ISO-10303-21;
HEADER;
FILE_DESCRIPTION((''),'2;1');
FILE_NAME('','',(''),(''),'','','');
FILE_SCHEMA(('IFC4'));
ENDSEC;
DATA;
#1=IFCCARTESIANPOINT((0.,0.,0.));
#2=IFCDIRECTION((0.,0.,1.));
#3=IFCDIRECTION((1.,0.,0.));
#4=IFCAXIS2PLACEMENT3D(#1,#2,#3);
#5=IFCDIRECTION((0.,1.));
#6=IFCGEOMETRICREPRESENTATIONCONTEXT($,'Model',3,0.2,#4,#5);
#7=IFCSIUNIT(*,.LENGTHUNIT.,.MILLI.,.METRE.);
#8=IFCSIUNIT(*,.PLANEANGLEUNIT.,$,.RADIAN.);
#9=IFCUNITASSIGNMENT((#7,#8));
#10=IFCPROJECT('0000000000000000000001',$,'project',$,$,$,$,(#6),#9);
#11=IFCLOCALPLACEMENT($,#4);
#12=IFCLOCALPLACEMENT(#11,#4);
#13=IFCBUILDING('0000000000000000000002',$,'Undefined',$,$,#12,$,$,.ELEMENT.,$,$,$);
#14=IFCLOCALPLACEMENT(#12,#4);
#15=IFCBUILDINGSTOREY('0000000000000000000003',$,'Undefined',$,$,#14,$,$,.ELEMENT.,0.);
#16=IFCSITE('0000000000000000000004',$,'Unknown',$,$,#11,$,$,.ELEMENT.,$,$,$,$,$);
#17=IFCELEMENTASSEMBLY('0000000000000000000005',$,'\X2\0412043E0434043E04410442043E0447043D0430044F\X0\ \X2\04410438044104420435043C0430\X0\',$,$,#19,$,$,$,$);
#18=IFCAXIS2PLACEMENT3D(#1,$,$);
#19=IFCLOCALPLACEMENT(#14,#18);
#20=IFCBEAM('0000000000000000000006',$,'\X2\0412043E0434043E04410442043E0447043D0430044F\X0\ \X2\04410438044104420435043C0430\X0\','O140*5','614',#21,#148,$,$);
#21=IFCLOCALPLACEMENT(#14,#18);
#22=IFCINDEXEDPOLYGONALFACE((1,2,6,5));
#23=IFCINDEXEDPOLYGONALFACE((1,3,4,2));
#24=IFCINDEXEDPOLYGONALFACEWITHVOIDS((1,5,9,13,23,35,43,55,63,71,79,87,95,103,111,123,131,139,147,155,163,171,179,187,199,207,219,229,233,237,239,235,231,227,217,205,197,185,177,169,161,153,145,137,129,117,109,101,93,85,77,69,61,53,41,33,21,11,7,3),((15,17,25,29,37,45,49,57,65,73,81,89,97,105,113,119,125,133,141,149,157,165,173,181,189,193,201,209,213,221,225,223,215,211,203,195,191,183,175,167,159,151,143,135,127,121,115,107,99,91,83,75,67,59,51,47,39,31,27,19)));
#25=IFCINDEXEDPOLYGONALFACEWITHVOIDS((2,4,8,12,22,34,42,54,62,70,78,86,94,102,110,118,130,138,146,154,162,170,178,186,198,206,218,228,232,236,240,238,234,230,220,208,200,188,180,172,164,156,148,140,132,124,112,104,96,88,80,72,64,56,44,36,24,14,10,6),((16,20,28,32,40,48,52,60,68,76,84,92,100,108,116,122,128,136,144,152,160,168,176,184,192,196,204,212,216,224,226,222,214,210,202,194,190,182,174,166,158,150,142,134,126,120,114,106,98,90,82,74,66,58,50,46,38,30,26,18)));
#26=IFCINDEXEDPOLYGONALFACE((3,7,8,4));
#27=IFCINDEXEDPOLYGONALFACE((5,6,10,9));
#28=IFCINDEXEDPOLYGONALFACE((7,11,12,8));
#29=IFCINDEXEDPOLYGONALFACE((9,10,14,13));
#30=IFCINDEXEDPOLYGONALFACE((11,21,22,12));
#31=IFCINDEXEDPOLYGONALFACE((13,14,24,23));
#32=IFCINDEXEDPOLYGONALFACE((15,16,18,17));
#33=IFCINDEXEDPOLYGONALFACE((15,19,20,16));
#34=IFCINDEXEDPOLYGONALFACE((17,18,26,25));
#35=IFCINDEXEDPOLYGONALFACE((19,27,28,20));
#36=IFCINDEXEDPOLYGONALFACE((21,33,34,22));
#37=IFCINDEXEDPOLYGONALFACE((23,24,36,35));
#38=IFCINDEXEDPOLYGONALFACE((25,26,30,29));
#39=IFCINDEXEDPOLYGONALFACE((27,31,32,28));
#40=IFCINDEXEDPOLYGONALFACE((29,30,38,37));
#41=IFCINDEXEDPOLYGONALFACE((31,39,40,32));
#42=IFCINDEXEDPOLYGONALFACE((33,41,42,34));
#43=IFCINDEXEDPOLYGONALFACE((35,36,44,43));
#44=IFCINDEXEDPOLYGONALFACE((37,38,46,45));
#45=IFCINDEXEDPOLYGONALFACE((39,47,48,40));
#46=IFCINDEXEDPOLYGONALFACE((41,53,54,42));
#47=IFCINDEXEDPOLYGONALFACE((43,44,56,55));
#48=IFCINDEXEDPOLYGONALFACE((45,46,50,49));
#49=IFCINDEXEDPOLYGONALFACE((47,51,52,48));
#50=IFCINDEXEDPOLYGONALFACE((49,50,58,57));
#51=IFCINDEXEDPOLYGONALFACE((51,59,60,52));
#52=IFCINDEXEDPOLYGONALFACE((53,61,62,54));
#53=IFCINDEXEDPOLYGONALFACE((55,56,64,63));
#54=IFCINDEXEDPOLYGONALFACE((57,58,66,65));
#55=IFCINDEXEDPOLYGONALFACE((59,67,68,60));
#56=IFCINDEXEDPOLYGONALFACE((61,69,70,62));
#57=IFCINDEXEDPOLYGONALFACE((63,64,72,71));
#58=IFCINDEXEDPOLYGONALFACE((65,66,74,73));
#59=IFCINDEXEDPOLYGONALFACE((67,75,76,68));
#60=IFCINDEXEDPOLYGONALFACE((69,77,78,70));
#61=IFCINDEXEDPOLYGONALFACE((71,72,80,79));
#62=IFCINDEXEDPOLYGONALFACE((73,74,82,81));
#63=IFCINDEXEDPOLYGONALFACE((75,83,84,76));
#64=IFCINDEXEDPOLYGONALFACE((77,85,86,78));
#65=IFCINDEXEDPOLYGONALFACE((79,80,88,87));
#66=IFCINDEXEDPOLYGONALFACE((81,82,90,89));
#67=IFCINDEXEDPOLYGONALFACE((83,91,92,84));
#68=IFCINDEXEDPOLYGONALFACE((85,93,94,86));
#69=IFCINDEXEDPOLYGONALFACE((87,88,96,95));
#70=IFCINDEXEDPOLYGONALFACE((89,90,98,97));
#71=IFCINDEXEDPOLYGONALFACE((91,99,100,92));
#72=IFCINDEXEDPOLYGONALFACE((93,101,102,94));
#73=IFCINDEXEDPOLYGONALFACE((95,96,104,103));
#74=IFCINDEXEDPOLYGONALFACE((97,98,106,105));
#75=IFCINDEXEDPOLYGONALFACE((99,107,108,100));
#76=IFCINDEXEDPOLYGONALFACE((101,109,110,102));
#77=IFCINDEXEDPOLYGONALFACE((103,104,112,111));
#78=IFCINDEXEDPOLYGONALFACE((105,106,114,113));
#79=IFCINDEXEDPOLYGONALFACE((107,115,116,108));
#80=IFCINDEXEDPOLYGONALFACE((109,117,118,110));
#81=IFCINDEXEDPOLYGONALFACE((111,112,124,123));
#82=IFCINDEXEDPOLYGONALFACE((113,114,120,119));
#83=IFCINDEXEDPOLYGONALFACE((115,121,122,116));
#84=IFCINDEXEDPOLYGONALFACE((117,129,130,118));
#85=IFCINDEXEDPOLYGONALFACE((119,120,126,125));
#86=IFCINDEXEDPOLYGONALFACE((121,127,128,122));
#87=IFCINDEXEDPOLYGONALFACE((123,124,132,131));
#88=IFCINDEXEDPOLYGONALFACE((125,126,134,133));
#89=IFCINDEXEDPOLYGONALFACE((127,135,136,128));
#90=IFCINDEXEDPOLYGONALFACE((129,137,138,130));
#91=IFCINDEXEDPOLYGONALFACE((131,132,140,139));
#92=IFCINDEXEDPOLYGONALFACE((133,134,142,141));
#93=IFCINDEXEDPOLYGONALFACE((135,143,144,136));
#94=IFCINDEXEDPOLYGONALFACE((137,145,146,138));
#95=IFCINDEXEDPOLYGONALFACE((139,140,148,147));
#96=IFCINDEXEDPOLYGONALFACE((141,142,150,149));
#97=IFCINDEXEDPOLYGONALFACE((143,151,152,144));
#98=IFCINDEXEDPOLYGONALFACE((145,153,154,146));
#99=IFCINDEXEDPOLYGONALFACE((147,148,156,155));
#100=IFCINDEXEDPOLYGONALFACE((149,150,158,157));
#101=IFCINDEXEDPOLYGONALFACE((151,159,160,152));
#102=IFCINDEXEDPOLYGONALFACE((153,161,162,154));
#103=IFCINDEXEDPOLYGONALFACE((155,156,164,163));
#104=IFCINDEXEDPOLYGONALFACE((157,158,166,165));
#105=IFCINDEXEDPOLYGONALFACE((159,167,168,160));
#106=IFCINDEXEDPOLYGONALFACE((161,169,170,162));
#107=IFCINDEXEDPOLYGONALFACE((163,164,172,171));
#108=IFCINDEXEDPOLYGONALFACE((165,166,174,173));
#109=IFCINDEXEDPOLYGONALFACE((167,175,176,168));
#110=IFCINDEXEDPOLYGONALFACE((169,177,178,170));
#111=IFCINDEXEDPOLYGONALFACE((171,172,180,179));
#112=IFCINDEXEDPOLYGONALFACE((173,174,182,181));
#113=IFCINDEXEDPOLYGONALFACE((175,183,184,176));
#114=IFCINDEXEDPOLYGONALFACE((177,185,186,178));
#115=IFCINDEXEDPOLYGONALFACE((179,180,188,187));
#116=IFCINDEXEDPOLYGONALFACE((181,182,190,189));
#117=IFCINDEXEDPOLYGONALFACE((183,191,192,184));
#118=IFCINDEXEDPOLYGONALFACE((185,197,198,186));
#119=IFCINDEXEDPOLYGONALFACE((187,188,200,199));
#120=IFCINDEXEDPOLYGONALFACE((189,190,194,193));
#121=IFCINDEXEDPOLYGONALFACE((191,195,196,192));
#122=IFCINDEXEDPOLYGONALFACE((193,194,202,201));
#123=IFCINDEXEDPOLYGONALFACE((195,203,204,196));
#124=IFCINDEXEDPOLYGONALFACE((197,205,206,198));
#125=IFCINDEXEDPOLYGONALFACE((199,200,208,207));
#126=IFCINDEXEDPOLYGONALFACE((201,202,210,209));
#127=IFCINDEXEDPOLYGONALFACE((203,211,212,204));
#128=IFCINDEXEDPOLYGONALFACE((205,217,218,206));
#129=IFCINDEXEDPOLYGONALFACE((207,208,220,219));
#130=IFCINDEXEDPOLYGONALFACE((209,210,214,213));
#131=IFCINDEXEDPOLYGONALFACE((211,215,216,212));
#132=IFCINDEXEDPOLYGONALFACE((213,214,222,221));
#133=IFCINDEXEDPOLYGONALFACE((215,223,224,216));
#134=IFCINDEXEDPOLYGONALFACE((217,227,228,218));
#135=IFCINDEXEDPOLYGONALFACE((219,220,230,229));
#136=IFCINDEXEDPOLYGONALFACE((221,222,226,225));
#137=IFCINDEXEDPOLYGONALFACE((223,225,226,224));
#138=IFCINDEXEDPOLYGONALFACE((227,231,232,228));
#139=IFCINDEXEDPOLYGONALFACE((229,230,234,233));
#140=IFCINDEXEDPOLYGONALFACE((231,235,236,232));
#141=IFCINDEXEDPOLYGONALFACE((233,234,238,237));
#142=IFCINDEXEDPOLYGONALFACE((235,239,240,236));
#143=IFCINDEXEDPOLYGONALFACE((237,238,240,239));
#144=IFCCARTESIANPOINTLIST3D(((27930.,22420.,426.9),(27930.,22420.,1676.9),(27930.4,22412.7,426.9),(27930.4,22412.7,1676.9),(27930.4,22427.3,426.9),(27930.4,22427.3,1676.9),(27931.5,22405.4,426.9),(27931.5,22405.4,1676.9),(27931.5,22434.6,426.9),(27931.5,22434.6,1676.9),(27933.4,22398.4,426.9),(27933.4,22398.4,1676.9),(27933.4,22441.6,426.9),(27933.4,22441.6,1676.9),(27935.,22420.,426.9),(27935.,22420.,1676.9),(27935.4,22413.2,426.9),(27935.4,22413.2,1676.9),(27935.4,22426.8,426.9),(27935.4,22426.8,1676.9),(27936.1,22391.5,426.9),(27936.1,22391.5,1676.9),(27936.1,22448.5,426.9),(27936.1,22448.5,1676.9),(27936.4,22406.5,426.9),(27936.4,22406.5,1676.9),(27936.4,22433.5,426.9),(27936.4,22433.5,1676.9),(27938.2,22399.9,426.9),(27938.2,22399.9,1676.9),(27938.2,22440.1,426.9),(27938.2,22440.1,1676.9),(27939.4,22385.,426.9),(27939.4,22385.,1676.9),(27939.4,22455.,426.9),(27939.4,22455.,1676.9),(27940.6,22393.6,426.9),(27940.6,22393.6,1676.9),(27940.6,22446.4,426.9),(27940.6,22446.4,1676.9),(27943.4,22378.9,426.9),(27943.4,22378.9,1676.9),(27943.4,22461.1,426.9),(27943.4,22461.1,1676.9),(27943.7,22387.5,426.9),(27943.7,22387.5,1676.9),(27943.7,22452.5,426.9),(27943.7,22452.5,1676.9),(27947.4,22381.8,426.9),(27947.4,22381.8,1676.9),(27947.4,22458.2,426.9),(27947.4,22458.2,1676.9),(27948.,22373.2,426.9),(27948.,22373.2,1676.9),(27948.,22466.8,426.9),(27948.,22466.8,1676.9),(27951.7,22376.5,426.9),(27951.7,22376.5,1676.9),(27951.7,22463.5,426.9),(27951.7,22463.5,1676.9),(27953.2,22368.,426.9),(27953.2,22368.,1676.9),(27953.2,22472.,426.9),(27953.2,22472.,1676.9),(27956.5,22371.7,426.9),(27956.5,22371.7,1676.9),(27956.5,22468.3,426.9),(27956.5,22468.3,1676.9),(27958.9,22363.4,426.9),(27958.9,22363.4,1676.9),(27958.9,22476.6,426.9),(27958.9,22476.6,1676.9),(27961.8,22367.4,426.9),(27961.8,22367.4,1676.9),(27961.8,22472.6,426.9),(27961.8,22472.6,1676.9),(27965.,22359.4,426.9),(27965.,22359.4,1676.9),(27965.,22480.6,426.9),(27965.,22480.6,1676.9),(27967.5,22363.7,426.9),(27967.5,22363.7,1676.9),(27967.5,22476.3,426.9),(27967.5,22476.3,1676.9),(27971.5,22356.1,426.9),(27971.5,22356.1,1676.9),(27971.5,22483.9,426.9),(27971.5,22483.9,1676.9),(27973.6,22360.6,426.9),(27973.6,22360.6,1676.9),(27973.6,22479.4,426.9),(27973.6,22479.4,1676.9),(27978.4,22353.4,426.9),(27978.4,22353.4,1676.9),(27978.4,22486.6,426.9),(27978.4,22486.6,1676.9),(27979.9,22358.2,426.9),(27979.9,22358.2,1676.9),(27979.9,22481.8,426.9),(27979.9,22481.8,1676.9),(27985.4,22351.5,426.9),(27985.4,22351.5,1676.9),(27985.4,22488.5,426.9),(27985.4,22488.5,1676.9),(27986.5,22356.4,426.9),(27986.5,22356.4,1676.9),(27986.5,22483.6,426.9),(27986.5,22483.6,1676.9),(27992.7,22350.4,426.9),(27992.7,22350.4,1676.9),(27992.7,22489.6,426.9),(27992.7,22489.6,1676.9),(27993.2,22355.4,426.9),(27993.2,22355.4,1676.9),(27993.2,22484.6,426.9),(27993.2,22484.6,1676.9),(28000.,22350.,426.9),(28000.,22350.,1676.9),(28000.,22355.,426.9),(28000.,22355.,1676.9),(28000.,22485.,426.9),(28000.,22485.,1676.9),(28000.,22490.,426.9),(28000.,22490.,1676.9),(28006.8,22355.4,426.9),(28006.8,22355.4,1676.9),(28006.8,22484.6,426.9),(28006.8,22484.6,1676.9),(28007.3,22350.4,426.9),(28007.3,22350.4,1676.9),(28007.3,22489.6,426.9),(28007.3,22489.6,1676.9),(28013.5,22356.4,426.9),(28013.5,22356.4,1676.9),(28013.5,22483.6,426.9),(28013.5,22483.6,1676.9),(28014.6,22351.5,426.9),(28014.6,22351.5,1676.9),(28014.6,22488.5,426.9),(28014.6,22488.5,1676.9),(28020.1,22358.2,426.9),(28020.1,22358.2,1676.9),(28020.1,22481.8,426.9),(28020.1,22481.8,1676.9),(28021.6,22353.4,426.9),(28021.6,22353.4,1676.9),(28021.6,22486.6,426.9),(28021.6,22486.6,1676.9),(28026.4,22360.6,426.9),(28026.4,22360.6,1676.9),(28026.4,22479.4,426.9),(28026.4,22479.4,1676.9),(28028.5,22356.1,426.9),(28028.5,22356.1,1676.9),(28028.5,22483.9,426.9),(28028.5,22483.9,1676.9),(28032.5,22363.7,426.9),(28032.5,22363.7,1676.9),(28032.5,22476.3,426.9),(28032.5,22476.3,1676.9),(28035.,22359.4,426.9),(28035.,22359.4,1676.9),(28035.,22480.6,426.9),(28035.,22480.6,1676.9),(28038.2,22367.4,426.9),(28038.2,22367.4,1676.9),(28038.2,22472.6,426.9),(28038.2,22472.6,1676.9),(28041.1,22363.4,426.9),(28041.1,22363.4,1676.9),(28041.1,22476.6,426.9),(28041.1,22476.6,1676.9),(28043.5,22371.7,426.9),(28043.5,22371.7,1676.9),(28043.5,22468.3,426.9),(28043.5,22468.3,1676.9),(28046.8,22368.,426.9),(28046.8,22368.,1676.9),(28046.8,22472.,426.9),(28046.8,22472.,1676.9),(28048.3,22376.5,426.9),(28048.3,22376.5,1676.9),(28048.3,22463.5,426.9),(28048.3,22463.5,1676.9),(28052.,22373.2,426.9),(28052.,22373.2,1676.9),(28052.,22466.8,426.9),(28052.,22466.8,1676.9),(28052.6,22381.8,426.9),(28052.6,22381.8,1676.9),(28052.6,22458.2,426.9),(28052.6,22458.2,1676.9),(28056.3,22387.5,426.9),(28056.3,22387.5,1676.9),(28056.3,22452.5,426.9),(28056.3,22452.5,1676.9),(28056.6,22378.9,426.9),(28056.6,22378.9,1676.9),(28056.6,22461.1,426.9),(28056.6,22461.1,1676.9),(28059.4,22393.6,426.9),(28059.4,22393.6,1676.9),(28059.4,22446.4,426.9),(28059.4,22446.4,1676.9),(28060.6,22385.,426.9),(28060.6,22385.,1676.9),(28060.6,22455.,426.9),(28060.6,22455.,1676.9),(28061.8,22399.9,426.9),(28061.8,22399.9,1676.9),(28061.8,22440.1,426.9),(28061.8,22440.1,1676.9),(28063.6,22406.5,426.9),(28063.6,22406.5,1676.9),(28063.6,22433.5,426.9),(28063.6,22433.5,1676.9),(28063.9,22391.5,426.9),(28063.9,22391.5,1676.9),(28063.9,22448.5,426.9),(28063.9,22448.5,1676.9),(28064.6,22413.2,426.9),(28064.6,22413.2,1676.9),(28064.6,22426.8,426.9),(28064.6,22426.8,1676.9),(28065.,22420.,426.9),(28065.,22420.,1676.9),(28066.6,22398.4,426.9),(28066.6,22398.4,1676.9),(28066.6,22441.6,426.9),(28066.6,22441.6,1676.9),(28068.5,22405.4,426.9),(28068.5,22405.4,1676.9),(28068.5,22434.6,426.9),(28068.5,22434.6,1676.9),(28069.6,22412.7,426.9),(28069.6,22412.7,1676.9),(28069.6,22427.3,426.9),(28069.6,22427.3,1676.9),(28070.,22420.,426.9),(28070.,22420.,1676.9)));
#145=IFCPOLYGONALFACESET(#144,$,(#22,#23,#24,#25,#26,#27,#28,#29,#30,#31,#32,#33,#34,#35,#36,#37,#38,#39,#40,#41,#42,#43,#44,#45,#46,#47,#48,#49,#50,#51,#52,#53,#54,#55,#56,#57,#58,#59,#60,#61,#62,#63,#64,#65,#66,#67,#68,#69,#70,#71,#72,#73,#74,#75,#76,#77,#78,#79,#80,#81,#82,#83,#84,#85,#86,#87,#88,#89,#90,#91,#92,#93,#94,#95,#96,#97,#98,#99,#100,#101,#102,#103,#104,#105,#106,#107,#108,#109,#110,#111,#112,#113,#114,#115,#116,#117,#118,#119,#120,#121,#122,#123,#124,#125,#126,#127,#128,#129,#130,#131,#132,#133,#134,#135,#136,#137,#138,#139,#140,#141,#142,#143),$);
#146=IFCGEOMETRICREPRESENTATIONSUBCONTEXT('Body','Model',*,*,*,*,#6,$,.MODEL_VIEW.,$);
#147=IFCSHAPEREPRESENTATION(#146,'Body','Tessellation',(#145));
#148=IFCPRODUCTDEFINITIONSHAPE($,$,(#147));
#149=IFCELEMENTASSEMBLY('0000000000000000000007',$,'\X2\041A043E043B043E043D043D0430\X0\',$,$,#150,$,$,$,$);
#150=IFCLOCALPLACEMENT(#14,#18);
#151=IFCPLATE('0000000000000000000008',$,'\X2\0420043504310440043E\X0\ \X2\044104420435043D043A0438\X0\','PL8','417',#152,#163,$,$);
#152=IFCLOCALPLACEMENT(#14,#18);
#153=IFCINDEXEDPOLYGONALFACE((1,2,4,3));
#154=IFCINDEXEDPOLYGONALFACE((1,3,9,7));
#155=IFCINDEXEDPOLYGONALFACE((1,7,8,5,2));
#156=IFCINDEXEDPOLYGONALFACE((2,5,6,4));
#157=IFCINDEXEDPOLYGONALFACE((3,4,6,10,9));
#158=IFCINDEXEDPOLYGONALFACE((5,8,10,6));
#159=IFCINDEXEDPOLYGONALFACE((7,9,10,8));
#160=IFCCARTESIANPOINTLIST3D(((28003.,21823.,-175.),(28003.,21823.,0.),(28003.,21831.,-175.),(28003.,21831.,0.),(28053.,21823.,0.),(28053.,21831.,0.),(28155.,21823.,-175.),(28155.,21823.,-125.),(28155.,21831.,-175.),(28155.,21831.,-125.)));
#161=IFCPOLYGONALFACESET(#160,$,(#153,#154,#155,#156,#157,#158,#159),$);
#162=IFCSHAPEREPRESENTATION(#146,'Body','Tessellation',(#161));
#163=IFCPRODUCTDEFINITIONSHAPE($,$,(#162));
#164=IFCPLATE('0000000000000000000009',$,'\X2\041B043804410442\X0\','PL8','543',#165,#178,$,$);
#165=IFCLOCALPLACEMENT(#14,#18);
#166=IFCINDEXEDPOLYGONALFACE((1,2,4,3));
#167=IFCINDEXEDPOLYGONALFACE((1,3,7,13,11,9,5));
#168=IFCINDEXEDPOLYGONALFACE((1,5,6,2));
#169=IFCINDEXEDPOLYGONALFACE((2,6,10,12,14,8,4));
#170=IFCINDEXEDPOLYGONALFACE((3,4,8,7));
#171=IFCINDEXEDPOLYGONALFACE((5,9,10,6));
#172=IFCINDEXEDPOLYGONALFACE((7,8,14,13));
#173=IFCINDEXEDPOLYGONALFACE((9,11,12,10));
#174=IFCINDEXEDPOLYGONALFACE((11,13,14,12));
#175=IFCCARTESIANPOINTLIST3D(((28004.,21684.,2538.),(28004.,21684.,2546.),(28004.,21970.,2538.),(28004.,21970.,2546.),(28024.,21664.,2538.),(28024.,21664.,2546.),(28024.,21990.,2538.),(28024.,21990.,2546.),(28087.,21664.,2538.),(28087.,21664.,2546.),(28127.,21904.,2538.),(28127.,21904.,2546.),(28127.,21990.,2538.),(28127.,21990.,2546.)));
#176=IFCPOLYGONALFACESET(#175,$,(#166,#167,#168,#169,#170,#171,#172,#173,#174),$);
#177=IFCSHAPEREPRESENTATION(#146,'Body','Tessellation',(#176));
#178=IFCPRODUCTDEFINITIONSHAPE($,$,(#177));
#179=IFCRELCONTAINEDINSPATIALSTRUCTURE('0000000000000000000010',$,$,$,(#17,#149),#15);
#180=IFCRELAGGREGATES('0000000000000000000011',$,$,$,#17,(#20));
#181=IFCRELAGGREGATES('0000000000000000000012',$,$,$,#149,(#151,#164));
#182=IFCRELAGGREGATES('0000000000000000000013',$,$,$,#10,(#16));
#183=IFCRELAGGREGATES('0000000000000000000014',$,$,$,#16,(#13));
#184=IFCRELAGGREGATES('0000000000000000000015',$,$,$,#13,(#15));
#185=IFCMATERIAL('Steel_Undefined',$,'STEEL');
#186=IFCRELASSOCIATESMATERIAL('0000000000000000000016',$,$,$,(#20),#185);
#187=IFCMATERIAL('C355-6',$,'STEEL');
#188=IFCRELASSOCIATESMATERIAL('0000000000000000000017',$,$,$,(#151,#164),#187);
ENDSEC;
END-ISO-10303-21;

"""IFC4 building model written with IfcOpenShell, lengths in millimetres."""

from ifc_helpers import new_model, si_unit, direction, frame, origin_with_axes, place, context, subcontext, project, spatial, line, indexed_curve, outline, extrude, material, element, aggregate, save


model = new_model("IFC4")

# Units and contexts
model_context = context("Model", 3, precision=0.2, world=origin_with_axes(), true_north=direction((0.0, 1.0)))
body_context = subcontext(model_context, "Body", "Model", "MODEL_VIEW")
ifc_project = project(units=[si_unit("LENGTHUNIT", "METRE", prefix="MILLI"), si_unit("PLANEANGLEUNIT", "RADIAN")], contexts=[model_context])

# Site, building, storey
site_placement = place(None, origin_with_axes())
site = spatial("IfcSite", under=ifc_project, at=site_placement, Name="Unknown", CompositionType="ELEMENT")
building_placement = place(site_placement, origin_with_axes())
building = spatial("IfcBuilding", under=site, at=building_placement, Name="Undefined", CompositionType="ELEMENT")
storey_placement = place(building_placement, origin_with_axes())
storey = spatial("IfcBuildingStorey", under=building, at=storey_placement, Name="Undefined", CompositionType="ELEMENT", Elevation=0.0)

# Element assembly, beam
ifc_material_1 = material(Name="C355-6", Category="STEEL")
ifc_material_2 = material(Name="Steel_Undefined", Category="STEEL")
assembly_1_placement = place(storey_placement, frame((28000.0, 22420.0, 1676.9), z_axis=(0.0, -1.0, 0.0), x_axis=(0.0, 0.0, -1.0)))
assembly_1 = element("IfcElementAssembly", 1, at=assembly_1_placement, inside=storey, Name="Водосточная система")
beam_1_placement = place(assembly_1_placement, origin_with_axes())
beam_1 = element("IfcBeam", 2, at=beam_1_placement, material=ifc_material_2, Name="Водосточная система", Description="O140*5", ObjectType="614", context=body_context, shape_type="SolidModel", body=[
    extrude(outline(indexed_curve([(70.0, 0.0), (69.6, 7.3), (68.5, 14.6), (66.6, 21.6), (63.9, 28.5), (60.6, 35.0), (56.6, 41.1), (52.0, 46.8), (46.8, 52.0), (41.1, 56.6), (35.0, 60.6), (28.5, 63.9), (21.6, 66.6), (14.6, 68.5), (7.3, 69.6), (0.0, 70.0), (-7.3, 69.6), (-14.6, 68.5), (-21.6, 66.6), (-28.5, 63.9), (-35.0, 60.6), (-41.1, 56.6), (-46.8, 52.0), (-52.0, 46.8), (-56.6, 41.1), (-60.6, 35.0), (-63.9, 28.5), (-66.6, 21.6), (-68.5, 14.6), (-69.6, 7.3), (-70.0, 0.0), (-69.6, -7.3), (-68.5, -14.6), (-66.6, -21.6), (-63.9, -28.5), (-60.6, -35.0), (-56.6, -41.1), (-52.0, -46.8), (-46.8, -52.0), (-41.1, -56.6), (-35.0, -60.6), (-28.5, -63.9), (-21.6, -66.6), (-14.6, -68.5), (-7.3, -69.6), (0.0, -70.0), (7.3, -69.6), (14.6, -68.5), (21.6, -66.6), (28.5, -63.9), (35.0, -60.6), (41.1, -56.6), (46.8, -52.0), (52.0, -46.8), (56.6, -41.1), (60.6, -35.0), (63.9, -28.5), (66.6, -21.6), (68.5, -14.6), (69.6, -7.3)], segments=[line(1, 2, 3, 4, 5, 6, 7, 8, 9, 10, 11, 12, 13, 14, 15, 16, 17, 18, 19, 20, 21, 22, 23, 24, 25, 26, 27, 28, 29, 30, 31, 32, 33, 34, 35, 36, 37, 38, 39, 40, 41, 42, 43, 44, 45, 46, 47, 48, 49, 50, 51, 52, 53, 54, 55, 56, 57, 58, 59, 60, 1)]), holes=[indexed_curve([(65.0, 0.0), (64.6, -6.8), (63.6, -13.5), (61.8, -20.1), (59.4, -26.4), (56.3, -32.5), (52.6, -38.2), (48.3, -43.5), (43.5, -48.3), (38.2, -52.6), (32.5, -56.3), (26.4, -59.4), (20.1, -61.8), (13.5, -63.6), (6.8, -64.6), (0.0, -65.0), (-6.8, -64.6), (-13.5, -63.6), (-20.1, -61.8), (-26.4, -59.4), (-32.5, -56.3), (-38.2, -52.6), (-43.5, -48.3), (-48.3, -43.5), (-52.6, -38.2), (-56.3, -32.5), (-59.4, -26.4), (-61.8, -20.1), (-63.6, -13.5), (-64.6, -6.8), (-65.0, 0.0), (-64.6, 6.8), (-63.6, 13.5), (-61.8, 20.1), (-59.4, 26.4), (-56.3, 32.5), (-52.6, 38.2), (-48.3, 43.5), (-43.5, 48.3), (-38.2, 52.6), (-32.5, 56.3), (-26.4, 59.4), (-20.1, 61.8), (-13.5, 63.6), (-6.8, 64.6), (0.0, 65.0), (6.8, 64.6), (13.5, 63.6), (20.1, 61.8), (26.4, 59.4), (32.5, 56.3), (38.2, 52.6), (43.5, 48.3), (48.3, 43.5), (52.6, 38.2), (56.3, 32.5), (59.4, 26.4), (61.8, 20.1), (63.6, 13.5), (64.6, 6.8)], segments=[line(1, 2, 3, 4, 5, 6, 7, 8, 9, 10, 11, 12, 13, 14, 15, 16, 17, 18, 19, 20, 21, 22, 23, 24, 25, 26, 27, 28, 29, 30, 31, 32, 33, 34, 35, 36, 37, 38, 39, 40, 41, 42, 43, 44, 45, 46, 47, 48, 49, 50, 51, 52, 53, 54, 55, 56, 57, 58, 59, 60, 1)])]), frame((0.0, 0.0, 0.0), z_axis=(-1.0, 0.0, 0.0), x_axis=(0.0, 0.0, 1.0)), (0.0, 0.0, -1.0), 1250.0),
])
aggregate(assembly_1, [beam_1])

# Element assembly, plates
assembly_2_placement = place(storey_placement, frame((28000.0, 21827.0, -200.0), z_axis=(-1.0, 0.0, 0.0), x_axis=(0.0, 0.0, 1.0)))
assembly_2 = element("IfcElementAssembly", 3, at=assembly_2_placement, inside=storey, Name="Колонна")
plate_1_placement = place(assembly_2_placement, frame((25.0, 0.0, -3.0), z_axis=(0.0, -1.0, 0.0), x_axis=(0.0, 0.0, -1.0)))
plate_1 = element("IfcPlate", 4, at=plate_1_placement, material=ifc_material_1, Name="Ребро стенки", Description="PL8", ObjectType="417", context=body_context, shape_type="SolidModel", body=[
    extrude(outline(indexed_curve([(0.0, 0.0), (152.0, 0.0), (152.0, 50.0), (50.0, 175.0), (0.0, 175.0)], segments=[line(1, 2, 3, 4, 5, 1)])), frame((0.0, 0.0, 4.0), z_axis=(0.0, 0.0, 1.0), x_axis=(1.0, 0.0, 0.0)), (0.0, 0.0, -1.0), 8.0),
])
plate_2_placement = place(assembly_2_placement, frame((2742.0, -163.0, -4.0), z_axis=(1.0, 0.0, 0.0), x_axis=(0.0, 0.0, -1.0)))
plate_2 = element("IfcPlate", 5, at=plate_2_placement, material=ifc_material_1, Name="Лист", Description="PL8", ObjectType="543", context=body_context, shape_type="SolidModel", body=[
    extrude(outline(indexed_curve([(0.0, 20.0), (20.0, 0.0), (83.0, 0.0), (123.0, 240.0), (123.0, 326.0), (20.0, 326.0), (0.0, 306.0)], segments=[line(1, 2, 3, 4, 5, 6, 7, 1)])), frame((0.0, 0.0, 4.0), z_axis=(0.0, 0.0, 1.0), x_axis=(1.0, 0.0, 0.0)), (0.0, 0.0, -1.0), 8.0),
])
aggregate(assembly_2, [plate_1, plate_2])

save(model, "model.ifc")
